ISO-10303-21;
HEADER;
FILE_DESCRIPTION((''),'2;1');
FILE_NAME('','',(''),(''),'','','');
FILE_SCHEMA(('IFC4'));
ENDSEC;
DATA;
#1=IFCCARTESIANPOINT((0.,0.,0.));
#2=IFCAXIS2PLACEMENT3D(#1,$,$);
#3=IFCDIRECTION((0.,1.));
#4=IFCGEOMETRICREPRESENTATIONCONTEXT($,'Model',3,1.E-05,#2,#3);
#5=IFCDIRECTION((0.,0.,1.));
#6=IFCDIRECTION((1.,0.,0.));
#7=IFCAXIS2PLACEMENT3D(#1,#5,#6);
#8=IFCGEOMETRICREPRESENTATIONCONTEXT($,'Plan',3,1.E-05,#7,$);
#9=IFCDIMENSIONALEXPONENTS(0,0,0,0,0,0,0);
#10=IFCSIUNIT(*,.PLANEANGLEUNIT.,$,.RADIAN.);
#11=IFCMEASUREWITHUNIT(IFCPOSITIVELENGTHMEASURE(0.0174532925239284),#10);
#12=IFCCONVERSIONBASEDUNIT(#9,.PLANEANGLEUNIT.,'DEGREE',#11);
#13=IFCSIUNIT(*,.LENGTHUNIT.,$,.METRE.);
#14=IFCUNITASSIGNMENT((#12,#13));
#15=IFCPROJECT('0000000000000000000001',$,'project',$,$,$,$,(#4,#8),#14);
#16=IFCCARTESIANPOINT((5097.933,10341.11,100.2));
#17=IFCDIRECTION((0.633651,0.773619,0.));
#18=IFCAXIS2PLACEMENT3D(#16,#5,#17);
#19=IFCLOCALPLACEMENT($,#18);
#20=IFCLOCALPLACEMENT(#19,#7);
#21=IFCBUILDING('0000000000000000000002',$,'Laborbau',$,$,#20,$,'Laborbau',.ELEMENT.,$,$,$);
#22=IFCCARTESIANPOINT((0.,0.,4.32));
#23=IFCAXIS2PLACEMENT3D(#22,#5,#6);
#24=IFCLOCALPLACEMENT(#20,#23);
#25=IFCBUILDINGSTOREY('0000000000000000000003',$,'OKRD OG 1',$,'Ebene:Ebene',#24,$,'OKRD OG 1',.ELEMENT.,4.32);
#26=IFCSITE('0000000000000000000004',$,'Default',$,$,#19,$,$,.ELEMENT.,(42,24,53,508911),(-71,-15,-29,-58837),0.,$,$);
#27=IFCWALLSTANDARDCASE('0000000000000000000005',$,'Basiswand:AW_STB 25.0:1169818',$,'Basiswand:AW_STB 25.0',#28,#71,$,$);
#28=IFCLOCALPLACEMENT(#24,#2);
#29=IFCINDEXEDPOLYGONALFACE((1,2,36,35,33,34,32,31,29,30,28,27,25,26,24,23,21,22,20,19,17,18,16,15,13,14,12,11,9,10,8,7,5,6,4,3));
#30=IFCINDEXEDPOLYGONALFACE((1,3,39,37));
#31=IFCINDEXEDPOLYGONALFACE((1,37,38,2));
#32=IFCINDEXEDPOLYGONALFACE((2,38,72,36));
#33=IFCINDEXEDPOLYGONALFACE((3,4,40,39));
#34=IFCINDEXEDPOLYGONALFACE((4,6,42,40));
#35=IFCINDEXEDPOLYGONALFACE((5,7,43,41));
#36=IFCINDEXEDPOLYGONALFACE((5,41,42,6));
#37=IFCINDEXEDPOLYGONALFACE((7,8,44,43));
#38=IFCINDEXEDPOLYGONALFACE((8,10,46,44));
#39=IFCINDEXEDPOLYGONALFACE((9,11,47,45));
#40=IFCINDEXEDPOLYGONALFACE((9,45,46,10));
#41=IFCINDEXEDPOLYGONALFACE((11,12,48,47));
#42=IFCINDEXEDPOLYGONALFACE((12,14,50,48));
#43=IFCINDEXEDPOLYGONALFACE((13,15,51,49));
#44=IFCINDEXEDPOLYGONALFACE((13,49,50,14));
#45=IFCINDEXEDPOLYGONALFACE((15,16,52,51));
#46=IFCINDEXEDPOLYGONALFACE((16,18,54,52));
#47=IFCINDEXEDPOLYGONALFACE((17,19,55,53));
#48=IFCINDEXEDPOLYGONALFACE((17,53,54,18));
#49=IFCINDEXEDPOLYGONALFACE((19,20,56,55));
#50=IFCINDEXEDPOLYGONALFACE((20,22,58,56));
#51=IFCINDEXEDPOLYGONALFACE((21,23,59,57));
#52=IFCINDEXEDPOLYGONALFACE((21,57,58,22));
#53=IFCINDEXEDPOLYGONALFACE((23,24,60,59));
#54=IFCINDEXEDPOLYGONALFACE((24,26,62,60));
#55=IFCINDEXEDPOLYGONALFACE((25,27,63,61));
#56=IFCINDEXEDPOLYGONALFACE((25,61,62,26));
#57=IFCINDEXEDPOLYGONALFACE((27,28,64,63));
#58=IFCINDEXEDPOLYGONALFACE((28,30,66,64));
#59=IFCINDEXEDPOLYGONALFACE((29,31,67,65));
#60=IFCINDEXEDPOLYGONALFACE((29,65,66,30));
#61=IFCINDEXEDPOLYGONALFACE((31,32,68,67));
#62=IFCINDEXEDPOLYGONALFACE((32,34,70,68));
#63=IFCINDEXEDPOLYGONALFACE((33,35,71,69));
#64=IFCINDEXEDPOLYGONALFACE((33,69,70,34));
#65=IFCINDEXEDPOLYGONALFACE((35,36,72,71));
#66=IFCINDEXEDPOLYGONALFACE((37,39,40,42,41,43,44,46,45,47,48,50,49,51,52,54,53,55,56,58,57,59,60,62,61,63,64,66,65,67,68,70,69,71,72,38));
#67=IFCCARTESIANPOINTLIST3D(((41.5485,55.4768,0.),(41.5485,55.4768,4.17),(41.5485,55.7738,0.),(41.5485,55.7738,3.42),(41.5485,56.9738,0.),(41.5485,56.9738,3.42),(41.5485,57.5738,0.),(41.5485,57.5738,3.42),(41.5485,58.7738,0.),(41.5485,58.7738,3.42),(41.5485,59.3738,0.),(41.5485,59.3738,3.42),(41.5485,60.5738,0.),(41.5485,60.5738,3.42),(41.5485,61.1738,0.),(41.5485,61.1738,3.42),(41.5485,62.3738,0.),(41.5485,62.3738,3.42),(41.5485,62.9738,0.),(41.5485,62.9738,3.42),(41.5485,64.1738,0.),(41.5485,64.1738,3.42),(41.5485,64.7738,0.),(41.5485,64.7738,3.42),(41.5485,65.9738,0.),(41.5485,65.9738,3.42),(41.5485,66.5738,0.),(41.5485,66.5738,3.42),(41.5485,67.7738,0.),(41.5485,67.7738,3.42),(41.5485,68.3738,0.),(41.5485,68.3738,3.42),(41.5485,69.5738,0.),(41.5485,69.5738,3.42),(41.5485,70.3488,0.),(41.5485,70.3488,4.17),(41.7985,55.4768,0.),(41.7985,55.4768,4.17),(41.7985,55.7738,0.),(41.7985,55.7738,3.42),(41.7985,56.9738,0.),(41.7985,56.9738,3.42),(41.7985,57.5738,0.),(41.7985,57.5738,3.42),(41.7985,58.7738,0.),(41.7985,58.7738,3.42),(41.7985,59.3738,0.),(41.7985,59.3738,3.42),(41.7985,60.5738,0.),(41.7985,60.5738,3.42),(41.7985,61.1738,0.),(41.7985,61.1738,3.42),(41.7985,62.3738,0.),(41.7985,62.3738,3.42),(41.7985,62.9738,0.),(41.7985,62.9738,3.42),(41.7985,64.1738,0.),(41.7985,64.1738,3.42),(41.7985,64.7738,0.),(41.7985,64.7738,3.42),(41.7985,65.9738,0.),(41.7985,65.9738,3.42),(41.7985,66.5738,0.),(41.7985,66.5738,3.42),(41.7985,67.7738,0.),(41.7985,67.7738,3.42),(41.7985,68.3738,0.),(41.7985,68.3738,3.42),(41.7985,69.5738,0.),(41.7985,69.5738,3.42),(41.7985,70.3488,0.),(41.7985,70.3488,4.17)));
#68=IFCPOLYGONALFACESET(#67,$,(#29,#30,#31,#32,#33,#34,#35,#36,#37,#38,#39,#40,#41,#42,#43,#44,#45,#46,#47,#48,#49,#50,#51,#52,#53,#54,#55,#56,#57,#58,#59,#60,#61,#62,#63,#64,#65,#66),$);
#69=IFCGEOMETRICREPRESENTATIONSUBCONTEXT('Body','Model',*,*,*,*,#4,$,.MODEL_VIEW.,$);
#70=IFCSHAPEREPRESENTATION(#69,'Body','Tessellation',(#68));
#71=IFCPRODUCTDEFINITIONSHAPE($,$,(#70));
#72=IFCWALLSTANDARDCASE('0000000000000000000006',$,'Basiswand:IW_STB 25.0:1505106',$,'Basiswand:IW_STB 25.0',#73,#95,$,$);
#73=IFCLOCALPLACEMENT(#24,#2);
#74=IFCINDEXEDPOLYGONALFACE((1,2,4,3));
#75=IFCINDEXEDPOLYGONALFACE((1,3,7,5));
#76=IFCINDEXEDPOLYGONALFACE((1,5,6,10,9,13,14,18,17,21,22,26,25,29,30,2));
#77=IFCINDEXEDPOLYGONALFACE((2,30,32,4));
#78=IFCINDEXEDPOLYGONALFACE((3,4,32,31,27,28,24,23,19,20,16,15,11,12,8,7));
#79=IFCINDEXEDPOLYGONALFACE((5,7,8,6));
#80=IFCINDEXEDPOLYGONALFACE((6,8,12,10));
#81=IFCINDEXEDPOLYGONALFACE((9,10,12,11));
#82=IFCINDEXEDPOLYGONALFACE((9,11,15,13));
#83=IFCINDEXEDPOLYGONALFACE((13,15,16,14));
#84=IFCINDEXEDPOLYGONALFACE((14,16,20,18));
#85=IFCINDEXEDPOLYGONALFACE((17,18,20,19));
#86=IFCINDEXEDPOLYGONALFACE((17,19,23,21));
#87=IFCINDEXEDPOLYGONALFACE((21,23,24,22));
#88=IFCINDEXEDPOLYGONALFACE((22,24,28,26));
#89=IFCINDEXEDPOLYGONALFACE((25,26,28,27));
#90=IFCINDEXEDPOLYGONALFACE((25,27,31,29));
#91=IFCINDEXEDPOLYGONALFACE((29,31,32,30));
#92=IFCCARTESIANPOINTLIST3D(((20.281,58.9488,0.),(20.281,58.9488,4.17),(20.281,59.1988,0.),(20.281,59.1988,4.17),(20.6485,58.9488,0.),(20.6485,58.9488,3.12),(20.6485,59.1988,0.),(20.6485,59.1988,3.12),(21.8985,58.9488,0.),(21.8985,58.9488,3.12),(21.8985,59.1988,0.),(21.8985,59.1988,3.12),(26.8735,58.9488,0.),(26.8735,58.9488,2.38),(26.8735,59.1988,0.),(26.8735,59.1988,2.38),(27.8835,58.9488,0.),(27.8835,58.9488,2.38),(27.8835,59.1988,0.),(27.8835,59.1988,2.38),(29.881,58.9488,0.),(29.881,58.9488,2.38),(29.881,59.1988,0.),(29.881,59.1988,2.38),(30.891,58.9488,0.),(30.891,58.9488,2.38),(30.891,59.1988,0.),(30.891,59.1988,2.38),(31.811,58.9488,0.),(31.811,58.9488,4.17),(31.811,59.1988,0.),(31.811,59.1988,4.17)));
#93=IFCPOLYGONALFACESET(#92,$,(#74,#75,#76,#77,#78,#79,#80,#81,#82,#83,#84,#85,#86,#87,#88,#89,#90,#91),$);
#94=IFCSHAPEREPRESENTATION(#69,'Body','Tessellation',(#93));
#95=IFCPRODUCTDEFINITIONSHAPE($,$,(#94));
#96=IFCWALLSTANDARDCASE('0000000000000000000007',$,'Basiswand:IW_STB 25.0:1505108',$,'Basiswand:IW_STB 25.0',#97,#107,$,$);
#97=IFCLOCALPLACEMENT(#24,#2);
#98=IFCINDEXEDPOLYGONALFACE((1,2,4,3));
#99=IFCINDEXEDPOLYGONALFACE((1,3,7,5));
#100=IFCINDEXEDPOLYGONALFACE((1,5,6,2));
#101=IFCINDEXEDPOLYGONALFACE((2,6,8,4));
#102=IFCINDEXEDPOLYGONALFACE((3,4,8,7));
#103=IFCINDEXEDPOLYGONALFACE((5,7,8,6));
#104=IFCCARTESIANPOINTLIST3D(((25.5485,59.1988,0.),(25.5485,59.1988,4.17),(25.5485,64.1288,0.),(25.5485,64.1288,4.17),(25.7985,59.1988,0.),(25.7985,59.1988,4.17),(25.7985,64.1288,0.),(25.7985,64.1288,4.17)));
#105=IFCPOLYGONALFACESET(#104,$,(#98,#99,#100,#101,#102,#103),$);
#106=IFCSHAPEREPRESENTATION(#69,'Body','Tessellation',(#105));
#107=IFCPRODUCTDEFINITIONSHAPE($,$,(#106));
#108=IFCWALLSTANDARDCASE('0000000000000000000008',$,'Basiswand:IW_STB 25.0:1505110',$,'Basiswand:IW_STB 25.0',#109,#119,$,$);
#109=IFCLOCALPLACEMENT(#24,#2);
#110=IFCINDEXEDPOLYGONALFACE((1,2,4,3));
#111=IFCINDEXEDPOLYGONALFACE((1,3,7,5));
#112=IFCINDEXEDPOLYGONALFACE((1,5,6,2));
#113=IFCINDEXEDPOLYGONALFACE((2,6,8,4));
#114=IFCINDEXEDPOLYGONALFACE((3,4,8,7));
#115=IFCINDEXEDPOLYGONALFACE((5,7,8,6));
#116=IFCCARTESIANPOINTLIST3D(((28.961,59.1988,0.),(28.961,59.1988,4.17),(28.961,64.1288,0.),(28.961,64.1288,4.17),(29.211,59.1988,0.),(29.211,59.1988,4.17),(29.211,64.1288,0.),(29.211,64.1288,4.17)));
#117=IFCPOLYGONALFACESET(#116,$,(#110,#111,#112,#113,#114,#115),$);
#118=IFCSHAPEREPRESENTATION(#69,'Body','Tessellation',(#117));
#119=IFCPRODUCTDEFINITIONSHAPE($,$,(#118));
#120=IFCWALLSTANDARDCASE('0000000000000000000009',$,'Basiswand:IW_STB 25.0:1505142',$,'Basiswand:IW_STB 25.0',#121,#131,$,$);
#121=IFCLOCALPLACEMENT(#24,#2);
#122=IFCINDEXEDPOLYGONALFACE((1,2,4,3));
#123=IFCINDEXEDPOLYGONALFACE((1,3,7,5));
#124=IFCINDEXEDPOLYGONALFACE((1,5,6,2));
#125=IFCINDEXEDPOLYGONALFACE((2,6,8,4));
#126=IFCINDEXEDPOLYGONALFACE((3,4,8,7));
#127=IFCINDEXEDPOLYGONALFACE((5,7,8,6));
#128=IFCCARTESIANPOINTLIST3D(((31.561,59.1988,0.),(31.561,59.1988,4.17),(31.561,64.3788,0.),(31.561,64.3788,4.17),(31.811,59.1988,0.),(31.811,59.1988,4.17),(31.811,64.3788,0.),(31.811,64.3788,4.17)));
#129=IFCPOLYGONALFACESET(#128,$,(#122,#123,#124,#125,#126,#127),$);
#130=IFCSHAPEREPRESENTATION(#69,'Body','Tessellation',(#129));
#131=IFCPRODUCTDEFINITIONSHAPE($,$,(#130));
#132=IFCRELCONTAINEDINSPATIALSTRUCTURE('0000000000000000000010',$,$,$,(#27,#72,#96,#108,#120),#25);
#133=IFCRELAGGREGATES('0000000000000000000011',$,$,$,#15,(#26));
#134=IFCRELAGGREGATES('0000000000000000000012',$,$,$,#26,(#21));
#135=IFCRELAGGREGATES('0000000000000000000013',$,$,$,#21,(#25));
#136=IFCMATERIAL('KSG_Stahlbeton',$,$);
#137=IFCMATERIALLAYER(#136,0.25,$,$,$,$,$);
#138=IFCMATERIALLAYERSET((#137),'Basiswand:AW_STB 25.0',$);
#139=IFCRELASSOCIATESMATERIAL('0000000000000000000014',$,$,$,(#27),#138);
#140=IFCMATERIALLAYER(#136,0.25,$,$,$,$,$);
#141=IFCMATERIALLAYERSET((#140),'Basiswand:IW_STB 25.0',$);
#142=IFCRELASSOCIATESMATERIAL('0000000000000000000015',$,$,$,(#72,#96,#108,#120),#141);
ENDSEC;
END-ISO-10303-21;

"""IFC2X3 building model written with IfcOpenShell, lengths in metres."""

from ifc_helpers import new_model, entity, si_unit, converted_unit, direction, frame, frame_2d, origin, origin_with_axes, place, context, subcontext, project, spatial, rectangle, extrude, material, layer, layer_set, layer_usage, element, save


model = new_model("IFC2X3")

# Units and contexts
model_context = context("Model", 3, precision=1e-05, world=origin(), true_north=direction((0.0, 1.0)))
plan_context = context("Plan", 3, precision=1e-05, world=origin_with_axes())
body_context = subcontext(model_context, "Body", "Model", "MODEL_VIEW")
ifc_project = project(units=[converted_unit("PLANEANGLEUNIT", "DEGREE", entity("IfcPositiveLengthMeasure", 0.0174532925239284), si_unit("PLANEANGLEUNIT", "RADIAN"), dimensions=[0, 0, 0, 0, 0, 0, 0]), si_unit("LENGTHUNIT", "METRE")], contexts=[model_context, plan_context])

# Site, building, storey
site_placement = place(None, frame((5097.933, 10341.11, 100.2), z_axis=(0.0, 0.0, 1.0), x_axis=(0.633651, 0.773619, 0.0)))
site = spatial("IfcSite", under=ifc_project, at=site_placement, Name="Default", CompositionType="ELEMENT", RefLatitude=(42, 24, 53, 508911), RefLongitude=(-71, -15, -29, -58837), RefElevation=0.0)
building_placement = place(site_placement, origin_with_axes())
building = spatial("IfcBuilding", under=site, at=building_placement, Name="Laborbau", LongName="Laborbau", CompositionType="ELEMENT")
storey_placement = place(building_placement, frame((0.0, 0.0, 4.32), z_axis=(0.0, 0.0, 1.0), x_axis=(1.0, 0.0, 0.0)))
storey = spatial("IfcBuildingStorey", under=building, at=storey_placement, Name="OKRD OG 1", ObjectType="Ebene:Ebene", LongName="OKRD OG 1", CompositionType="ELEMENT", Elevation=4.32)

# Walls, openings
ifc_material_1 = material(Name="KSG_Stahlbeton")
ifc_layer_1 = layer(ifc_material_1, 0.25)
ifc_layer_set_1 = layer_set([ifc_layer_1], Name="Basiswand:AW_STB 25.0")
ifc_layer_usage_1 = layer_usage(ifc_layer_set_1, "AXIS2", "NEGATIVE", 0.125)
wall_1_placement = place(storey_placement, frame((41.6735, 70.3488, 0.0), z_axis=(0.0, 0.0, 1.0), x_axis=(0.0, -1.0, 0.0)))
wall_1 = element("IfcWallStandardCase", 1, at=wall_1_placement, inside=storey, material=ifc_layer_usage_1, Name="Basiswand:AW_STB 25.0:1169818", ObjectType="Basiswand:AW_STB 25.0", context=body_context, shape_type="SweptSolid", body=[
    extrude(rectangle(XDim=14.872, YDim=0.25, at=frame_2d((7.436, 0.0), x_axis=(-1.0, 0.0))), origin(), (0.0, 0.0, 1.0), 4.17),
])
opening_1_placement = place(wall_1_placement, frame((70.3488, -41.6735, 0.0), z_axis=(0.0, 0.0, 1.0), x_axis=(0.0, 1.0, 0.0)))
element("IfcOpeningElement", 2, at=opening_1_placement, cuts=wall_1, ObjectType="Opening", context=body_context, shape_type="SweptSolid", body=[
    extrude(rectangle(XDim=3.42, YDim=1.2, at=frame_2d((0.0, 0.0), x_axis=(0.0, 1.0))), frame((41.5485, 63.5738, 1.71), z_axis=(1.0, 0.0, 0.0), x_axis=(0.0, -1.0, 0.0)), (0.0, 0.0, 1.0), 0.25),
])
opening_2_placement = place(wall_1_placement, frame((70.3488, -41.6735, 0.0), z_axis=(0.0, 0.0, 1.0), x_axis=(0.0, 1.0, 0.0)))
element("IfcOpeningElement", 3, at=opening_2_placement, cuts=wall_1, ObjectType="Opening", context=body_context, shape_type="SweptSolid", body=[
    extrude(rectangle(XDim=3.42, YDim=1.2, at=frame_2d((0.0, 0.0), x_axis=(1.0, 0.0))), frame((41.5485, 68.9738, 1.71), z_axis=(1.0, 0.0, 0.0), x_axis=(0.0, 0.0, -1.0)), (0.0, 0.0, 1.0), 0.25),
])
opening_3_placement = place(wall_1_placement, frame((70.3488, -41.6735, 0.0), z_axis=(0.0, 0.0, 1.0), x_axis=(0.0, 1.0, 0.0)))
element("IfcOpeningElement", 4, at=opening_3_placement, cuts=wall_1, ObjectType="Opening", context=body_context, shape_type="SweptSolid", body=[
    extrude(rectangle(XDim=3.42, YDim=1.2, at=frame_2d((0.0, 0.0), x_axis=(0.0, 1.0))), frame((41.5485, 56.3738, 1.71), z_axis=(1.0, 0.0, 0.0), x_axis=(0.0, -1.0, 0.0)), (0.0, 0.0, 1.0), 0.25),
])
opening_4_placement = place(wall_1_placement, frame((70.3488, -41.6735, 0.0), z_axis=(0.0, 0.0, 1.0), x_axis=(0.0, 1.0, 0.0)))
element("IfcOpeningElement", 5, at=opening_4_placement, cuts=wall_1, ObjectType="Opening", context=body_context, shape_type="SweptSolid", body=[
    extrude(rectangle(XDim=3.42, YDim=1.2, at=frame_2d((0.0, 0.0), x_axis=(1.0, 0.0))), frame((41.5485, 58.1738, 1.71), z_axis=(1.0, 0.0, 0.0), x_axis=(0.0, 0.0, -1.0)), (0.0, 0.0, 1.0), 0.25),
])
opening_5_placement = place(wall_1_placement, frame((70.3488, -41.6735, 0.0), z_axis=(0.0, 0.0, 1.0), x_axis=(0.0, 1.0, 0.0)))
element("IfcOpeningElement", 6, at=opening_5_placement, cuts=wall_1, ObjectType="Opening", context=body_context, shape_type="SweptSolid", body=[
    extrude(rectangle(XDim=3.42, YDim=1.2, at=frame_2d((0.0, 0.0), x_axis=(0.0, 1.0))), frame((41.5485, 59.9738, 1.71), z_axis=(1.0, 0.0, 0.0), x_axis=(0.0, -1.0, 0.0)), (0.0, 0.0, 1.0), 0.25),
])
opening_6_placement = place(wall_1_placement, frame((70.3488, -41.6735, 0.0), z_axis=(0.0, 0.0, 1.0), x_axis=(0.0, 1.0, 0.0)))
element("IfcOpeningElement", 7, at=opening_6_placement, cuts=wall_1, ObjectType="Opening", context=body_context, shape_type="SweptSolid", body=[
    extrude(rectangle(XDim=3.42, YDim=1.2, at=frame_2d((0.0, 0.0), x_axis=(1.0, 0.0))), frame((41.5485, 61.7738, 1.71), z_axis=(1.0, 0.0, 0.0), x_axis=(0.0, 0.0, -1.0)), (0.0, 0.0, 1.0), 0.25),
])
opening_7_placement = place(wall_1_placement, frame((70.3488, -41.6735, 0.0), z_axis=(0.0, 0.0, 1.0), x_axis=(0.0, 1.0, 0.0)))
element("IfcOpeningElement", 8, at=opening_7_placement, cuts=wall_1, ObjectType="Opening", context=body_context, shape_type="SweptSolid", body=[
    extrude(rectangle(XDim=3.42, YDim=1.2, at=frame_2d((0.0, 0.0), x_axis=(1.0, 0.0))), frame((41.5485, 65.3738, 1.71), z_axis=(1.0, 0.0, 0.0), x_axis=(0.0, 0.0, -1.0)), (0.0, 0.0, 1.0), 0.25),
])
opening_8_placement = place(wall_1_placement, frame((70.3488, -41.6735, 0.0), z_axis=(0.0, 0.0, 1.0), x_axis=(0.0, 1.0, 0.0)))
element("IfcOpeningElement", 9, at=opening_8_placement, cuts=wall_1, ObjectType="Opening", context=body_context, shape_type="SweptSolid", body=[
    extrude(rectangle(XDim=3.42, YDim=1.2, at=frame_2d((0.0, 0.0), x_axis=(0.0, 1.0))), frame((41.5485, 67.1738, 1.71), z_axis=(1.0, 0.0, 0.0), x_axis=(0.0, -1.0, 0.0)), (0.0, 0.0, 1.0), 0.25),
])
ifc_layer_2 = layer(ifc_material_1, 0.25)
ifc_layer_set_2 = layer_set([ifc_layer_2], Name="Basiswand:IW_STB 25.0")
ifc_layer_usage_2 = layer_usage(ifc_layer_set_2, "AXIS2", "NEGATIVE", 0.125)
wall_2_placement = place(storey_placement, frame((31.811, 59.0738, 0.0), z_axis=(0.0, 0.0, 1.0), x_axis=(-1.0, 0.0, 0.0)))
wall_2 = element("IfcWallStandardCase", 10, at=wall_2_placement, inside=storey, material=ifc_layer_usage_2, Name="Basiswand:IW_STB 25.0:1505106", ObjectType="Basiswand:IW_STB 25.0", context=body_context, shape_type="SweptSolid", body=[
    extrude(rectangle(XDim=11.53, YDim=0.25, at=frame_2d((5.765, 0.0), x_axis=(-1.0, 0.0))), origin(), (0.0, 0.0, 1.0), 4.17),
])
opening_9_placement = place(wall_2_placement, frame((31.811, 59.0738, 0.0), z_axis=(0.0, 0.0, 1.0), x_axis=(-1.0, 0.0, 0.0)))
element("IfcOpeningElement", 11, at=opening_9_placement, cuts=wall_2, ObjectType="Opening", context=body_context, shape_type="SweptSolid", body=[
    extrude(rectangle(XDim=3.12, YDim=1.25, at=frame_2d((0.0, 0.0), x_axis=(0.0, 1.0))), frame((21.2735, 60.7228, 1.56), z_axis=(0.0, -1.0, 0.0), x_axis=(1.0, 0.0, 0.0)), (0.0, 0.0, 1.0), 3.048),
])
opening_10_placement = place(wall_2_placement, frame((11.1625, 0.125, 0.0), z_axis=(0.0, 0.0, 1.0), x_axis=(1.0, 0.0, 0.0)))
element("IfcOpeningElement", 12, at=opening_10_placement, cuts=wall_2, ObjectType="Opening", context=body_context, shape_type="SweptSolid", body=[
    extrude(rectangle(XDim=3.12, YDim=1.25, at=frame_2d((1.56, 0.625), x_axis=(1.0, 0.0))), frame((0.0, 0.0, 0.0), z_axis=(0.0, -1.0, 0.0), x_axis=(0.0, 0.0, 1.0)), (0.0, 0.0, 1.0), 0.25),
])
opening_11_placement = place(wall_2_placement, frame((31.811, 59.0738, 0.0), z_axis=(0.0, 0.0, 1.0), x_axis=(-1.0, 0.0, 0.0)))
element("IfcOpeningElement", 13, at=opening_11_placement, cuts=wall_2, ObjectType="Opening", context=body_context, shape_type="SweptSolid", body=[
    extrude(rectangle(XDim=2.38, YDim=1.01, at=frame_2d((0.0, 0.0), x_axis=(0.0, 1.0))), frame((27.3785, 60.7228, 1.19), z_axis=(0.0, -1.0, 0.0), x_axis=(1.0, 0.0, 0.0)), (0.0, 0.0, 1.0), 3.048),
])
opening_12_placement = place(wall_2_placement, frame((3.9275, -0.125, 0.0), z_axis=(0.0, 0.0, 1.0), x_axis=(1.0, 0.0, 0.0)))
element("IfcOpeningElement", 14, at=opening_12_placement, cuts=wall_2, ObjectType="Opening", context=body_context, shape_type="SweptSolid", body=[
    extrude(rectangle(XDim=2.38, YDim=1.01, at=frame_2d((1.19, 0.505), x_axis=(1.0, 0.0))), frame((0.0, 0.0, 0.0), z_axis=(0.0, 1.0, 0.0), x_axis=(0.0, 0.0, 1.0)), (0.0, 0.0, 1.0), 0.25),
])
opening_13_placement = place(wall_2_placement, frame((31.811, 59.0738, 0.0), z_axis=(0.0, 0.0, 1.0), x_axis=(-1.0, 0.0, 0.0)))
element("IfcOpeningElement", 15, at=opening_13_placement, cuts=wall_2, ObjectType="Opening", context=body_context, shape_type="SweptSolid", body=[
    extrude(rectangle(XDim=2.38, YDim=1.01, at=frame_2d((0.0, 0.0), x_axis=(0.0, 1.0))), frame((30.386, 60.7228, 1.19), z_axis=(0.0, -1.0, 0.0), x_axis=(1.0, 0.0, 0.0)), (0.0, 0.0, 1.0), 3.048),
])
opening_14_placement = place(wall_2_placement, frame((0.92, -0.125, 0.0), z_axis=(0.0, 0.0, 1.0), x_axis=(1.0, 0.0, 0.0)))
element("IfcOpeningElement", 16, at=opening_14_placement, cuts=wall_2, ObjectType="Opening", context=body_context, shape_type="SweptSolid", body=[
    extrude(rectangle(XDim=2.38, YDim=1.01, at=frame_2d((1.19, 0.505), x_axis=(1.0, 0.0))), frame((0.0, 0.0, 0.0), z_axis=(0.0, 1.0, 0.0), x_axis=(0.0, 0.0, 1.0)), (0.0, 0.0, 1.0), 0.25),
])

# Walls
ifc_layer_usage_3 = layer_usage(ifc_layer_set_2, "AXIS2", "POSITIVE", -0.125)
wall_3_placement = place(storey_placement, frame((25.6735, 64.1288, 0.0), z_axis=(0.0, 0.0, 1.0), x_axis=(0.0, -1.0, 0.0)))
element("IfcWallStandardCase", 17, at=wall_3_placement, inside=storey, material=ifc_layer_usage_3, Name="Basiswand:IW_STB 25.0:1505108", ObjectType="Basiswand:IW_STB 25.0", context=body_context, shape_type="SweptSolid", body=[
    extrude(rectangle(XDim=4.93, YDim=0.25, at=frame_2d((2.465, 0.0), x_axis=(-1.0, 0.0))), origin(), (0.0, 0.0, 1.0), 4.17),
])
ifc_layer_usage_4 = layer_usage(ifc_layer_set_2, "AXIS2", "POSITIVE", -0.125)
wall_4_placement = place(storey_placement, frame((29.086, 64.1288, 0.0), z_axis=(0.0, 0.0, 1.0), x_axis=(0.0, -1.0, 0.0)))
element("IfcWallStandardCase", 18, at=wall_4_placement, inside=storey, material=ifc_layer_usage_4, Name="Basiswand:IW_STB 25.0:1505110", ObjectType="Basiswand:IW_STB 25.0", context=body_context, shape_type="SweptSolid", body=[
    extrude(rectangle(XDim=4.93, YDim=0.25, at=frame_2d((2.465, 0.0), x_axis=(-1.0, 0.0))), origin(), (0.0, 0.0, 1.0), 4.17),
])
ifc_layer_usage_5 = layer_usage(ifc_layer_set_2, "AXIS2", "POSITIVE", -0.125)
wall_5_placement = place(storey_placement, frame((31.686, 64.3788, 0.0), z_axis=(0.0, 0.0, 1.0), x_axis=(0.0, -1.0, 0.0)))
element("IfcWallStandardCase", 19, at=wall_5_placement, inside=storey, material=ifc_layer_usage_5, Name="Basiswand:IW_STB 25.0:1505142", ObjectType="Basiswand:IW_STB 25.0", context=body_context, shape_type="SweptSolid", body=[
    extrude(rectangle(XDim=5.18, YDim=0.25, at=frame_2d((2.59, 0.0), x_axis=(-1.0, 0.0))), origin(), (0.0, 0.0, 1.0), 4.17),
])

save(model, "model.ifc")
